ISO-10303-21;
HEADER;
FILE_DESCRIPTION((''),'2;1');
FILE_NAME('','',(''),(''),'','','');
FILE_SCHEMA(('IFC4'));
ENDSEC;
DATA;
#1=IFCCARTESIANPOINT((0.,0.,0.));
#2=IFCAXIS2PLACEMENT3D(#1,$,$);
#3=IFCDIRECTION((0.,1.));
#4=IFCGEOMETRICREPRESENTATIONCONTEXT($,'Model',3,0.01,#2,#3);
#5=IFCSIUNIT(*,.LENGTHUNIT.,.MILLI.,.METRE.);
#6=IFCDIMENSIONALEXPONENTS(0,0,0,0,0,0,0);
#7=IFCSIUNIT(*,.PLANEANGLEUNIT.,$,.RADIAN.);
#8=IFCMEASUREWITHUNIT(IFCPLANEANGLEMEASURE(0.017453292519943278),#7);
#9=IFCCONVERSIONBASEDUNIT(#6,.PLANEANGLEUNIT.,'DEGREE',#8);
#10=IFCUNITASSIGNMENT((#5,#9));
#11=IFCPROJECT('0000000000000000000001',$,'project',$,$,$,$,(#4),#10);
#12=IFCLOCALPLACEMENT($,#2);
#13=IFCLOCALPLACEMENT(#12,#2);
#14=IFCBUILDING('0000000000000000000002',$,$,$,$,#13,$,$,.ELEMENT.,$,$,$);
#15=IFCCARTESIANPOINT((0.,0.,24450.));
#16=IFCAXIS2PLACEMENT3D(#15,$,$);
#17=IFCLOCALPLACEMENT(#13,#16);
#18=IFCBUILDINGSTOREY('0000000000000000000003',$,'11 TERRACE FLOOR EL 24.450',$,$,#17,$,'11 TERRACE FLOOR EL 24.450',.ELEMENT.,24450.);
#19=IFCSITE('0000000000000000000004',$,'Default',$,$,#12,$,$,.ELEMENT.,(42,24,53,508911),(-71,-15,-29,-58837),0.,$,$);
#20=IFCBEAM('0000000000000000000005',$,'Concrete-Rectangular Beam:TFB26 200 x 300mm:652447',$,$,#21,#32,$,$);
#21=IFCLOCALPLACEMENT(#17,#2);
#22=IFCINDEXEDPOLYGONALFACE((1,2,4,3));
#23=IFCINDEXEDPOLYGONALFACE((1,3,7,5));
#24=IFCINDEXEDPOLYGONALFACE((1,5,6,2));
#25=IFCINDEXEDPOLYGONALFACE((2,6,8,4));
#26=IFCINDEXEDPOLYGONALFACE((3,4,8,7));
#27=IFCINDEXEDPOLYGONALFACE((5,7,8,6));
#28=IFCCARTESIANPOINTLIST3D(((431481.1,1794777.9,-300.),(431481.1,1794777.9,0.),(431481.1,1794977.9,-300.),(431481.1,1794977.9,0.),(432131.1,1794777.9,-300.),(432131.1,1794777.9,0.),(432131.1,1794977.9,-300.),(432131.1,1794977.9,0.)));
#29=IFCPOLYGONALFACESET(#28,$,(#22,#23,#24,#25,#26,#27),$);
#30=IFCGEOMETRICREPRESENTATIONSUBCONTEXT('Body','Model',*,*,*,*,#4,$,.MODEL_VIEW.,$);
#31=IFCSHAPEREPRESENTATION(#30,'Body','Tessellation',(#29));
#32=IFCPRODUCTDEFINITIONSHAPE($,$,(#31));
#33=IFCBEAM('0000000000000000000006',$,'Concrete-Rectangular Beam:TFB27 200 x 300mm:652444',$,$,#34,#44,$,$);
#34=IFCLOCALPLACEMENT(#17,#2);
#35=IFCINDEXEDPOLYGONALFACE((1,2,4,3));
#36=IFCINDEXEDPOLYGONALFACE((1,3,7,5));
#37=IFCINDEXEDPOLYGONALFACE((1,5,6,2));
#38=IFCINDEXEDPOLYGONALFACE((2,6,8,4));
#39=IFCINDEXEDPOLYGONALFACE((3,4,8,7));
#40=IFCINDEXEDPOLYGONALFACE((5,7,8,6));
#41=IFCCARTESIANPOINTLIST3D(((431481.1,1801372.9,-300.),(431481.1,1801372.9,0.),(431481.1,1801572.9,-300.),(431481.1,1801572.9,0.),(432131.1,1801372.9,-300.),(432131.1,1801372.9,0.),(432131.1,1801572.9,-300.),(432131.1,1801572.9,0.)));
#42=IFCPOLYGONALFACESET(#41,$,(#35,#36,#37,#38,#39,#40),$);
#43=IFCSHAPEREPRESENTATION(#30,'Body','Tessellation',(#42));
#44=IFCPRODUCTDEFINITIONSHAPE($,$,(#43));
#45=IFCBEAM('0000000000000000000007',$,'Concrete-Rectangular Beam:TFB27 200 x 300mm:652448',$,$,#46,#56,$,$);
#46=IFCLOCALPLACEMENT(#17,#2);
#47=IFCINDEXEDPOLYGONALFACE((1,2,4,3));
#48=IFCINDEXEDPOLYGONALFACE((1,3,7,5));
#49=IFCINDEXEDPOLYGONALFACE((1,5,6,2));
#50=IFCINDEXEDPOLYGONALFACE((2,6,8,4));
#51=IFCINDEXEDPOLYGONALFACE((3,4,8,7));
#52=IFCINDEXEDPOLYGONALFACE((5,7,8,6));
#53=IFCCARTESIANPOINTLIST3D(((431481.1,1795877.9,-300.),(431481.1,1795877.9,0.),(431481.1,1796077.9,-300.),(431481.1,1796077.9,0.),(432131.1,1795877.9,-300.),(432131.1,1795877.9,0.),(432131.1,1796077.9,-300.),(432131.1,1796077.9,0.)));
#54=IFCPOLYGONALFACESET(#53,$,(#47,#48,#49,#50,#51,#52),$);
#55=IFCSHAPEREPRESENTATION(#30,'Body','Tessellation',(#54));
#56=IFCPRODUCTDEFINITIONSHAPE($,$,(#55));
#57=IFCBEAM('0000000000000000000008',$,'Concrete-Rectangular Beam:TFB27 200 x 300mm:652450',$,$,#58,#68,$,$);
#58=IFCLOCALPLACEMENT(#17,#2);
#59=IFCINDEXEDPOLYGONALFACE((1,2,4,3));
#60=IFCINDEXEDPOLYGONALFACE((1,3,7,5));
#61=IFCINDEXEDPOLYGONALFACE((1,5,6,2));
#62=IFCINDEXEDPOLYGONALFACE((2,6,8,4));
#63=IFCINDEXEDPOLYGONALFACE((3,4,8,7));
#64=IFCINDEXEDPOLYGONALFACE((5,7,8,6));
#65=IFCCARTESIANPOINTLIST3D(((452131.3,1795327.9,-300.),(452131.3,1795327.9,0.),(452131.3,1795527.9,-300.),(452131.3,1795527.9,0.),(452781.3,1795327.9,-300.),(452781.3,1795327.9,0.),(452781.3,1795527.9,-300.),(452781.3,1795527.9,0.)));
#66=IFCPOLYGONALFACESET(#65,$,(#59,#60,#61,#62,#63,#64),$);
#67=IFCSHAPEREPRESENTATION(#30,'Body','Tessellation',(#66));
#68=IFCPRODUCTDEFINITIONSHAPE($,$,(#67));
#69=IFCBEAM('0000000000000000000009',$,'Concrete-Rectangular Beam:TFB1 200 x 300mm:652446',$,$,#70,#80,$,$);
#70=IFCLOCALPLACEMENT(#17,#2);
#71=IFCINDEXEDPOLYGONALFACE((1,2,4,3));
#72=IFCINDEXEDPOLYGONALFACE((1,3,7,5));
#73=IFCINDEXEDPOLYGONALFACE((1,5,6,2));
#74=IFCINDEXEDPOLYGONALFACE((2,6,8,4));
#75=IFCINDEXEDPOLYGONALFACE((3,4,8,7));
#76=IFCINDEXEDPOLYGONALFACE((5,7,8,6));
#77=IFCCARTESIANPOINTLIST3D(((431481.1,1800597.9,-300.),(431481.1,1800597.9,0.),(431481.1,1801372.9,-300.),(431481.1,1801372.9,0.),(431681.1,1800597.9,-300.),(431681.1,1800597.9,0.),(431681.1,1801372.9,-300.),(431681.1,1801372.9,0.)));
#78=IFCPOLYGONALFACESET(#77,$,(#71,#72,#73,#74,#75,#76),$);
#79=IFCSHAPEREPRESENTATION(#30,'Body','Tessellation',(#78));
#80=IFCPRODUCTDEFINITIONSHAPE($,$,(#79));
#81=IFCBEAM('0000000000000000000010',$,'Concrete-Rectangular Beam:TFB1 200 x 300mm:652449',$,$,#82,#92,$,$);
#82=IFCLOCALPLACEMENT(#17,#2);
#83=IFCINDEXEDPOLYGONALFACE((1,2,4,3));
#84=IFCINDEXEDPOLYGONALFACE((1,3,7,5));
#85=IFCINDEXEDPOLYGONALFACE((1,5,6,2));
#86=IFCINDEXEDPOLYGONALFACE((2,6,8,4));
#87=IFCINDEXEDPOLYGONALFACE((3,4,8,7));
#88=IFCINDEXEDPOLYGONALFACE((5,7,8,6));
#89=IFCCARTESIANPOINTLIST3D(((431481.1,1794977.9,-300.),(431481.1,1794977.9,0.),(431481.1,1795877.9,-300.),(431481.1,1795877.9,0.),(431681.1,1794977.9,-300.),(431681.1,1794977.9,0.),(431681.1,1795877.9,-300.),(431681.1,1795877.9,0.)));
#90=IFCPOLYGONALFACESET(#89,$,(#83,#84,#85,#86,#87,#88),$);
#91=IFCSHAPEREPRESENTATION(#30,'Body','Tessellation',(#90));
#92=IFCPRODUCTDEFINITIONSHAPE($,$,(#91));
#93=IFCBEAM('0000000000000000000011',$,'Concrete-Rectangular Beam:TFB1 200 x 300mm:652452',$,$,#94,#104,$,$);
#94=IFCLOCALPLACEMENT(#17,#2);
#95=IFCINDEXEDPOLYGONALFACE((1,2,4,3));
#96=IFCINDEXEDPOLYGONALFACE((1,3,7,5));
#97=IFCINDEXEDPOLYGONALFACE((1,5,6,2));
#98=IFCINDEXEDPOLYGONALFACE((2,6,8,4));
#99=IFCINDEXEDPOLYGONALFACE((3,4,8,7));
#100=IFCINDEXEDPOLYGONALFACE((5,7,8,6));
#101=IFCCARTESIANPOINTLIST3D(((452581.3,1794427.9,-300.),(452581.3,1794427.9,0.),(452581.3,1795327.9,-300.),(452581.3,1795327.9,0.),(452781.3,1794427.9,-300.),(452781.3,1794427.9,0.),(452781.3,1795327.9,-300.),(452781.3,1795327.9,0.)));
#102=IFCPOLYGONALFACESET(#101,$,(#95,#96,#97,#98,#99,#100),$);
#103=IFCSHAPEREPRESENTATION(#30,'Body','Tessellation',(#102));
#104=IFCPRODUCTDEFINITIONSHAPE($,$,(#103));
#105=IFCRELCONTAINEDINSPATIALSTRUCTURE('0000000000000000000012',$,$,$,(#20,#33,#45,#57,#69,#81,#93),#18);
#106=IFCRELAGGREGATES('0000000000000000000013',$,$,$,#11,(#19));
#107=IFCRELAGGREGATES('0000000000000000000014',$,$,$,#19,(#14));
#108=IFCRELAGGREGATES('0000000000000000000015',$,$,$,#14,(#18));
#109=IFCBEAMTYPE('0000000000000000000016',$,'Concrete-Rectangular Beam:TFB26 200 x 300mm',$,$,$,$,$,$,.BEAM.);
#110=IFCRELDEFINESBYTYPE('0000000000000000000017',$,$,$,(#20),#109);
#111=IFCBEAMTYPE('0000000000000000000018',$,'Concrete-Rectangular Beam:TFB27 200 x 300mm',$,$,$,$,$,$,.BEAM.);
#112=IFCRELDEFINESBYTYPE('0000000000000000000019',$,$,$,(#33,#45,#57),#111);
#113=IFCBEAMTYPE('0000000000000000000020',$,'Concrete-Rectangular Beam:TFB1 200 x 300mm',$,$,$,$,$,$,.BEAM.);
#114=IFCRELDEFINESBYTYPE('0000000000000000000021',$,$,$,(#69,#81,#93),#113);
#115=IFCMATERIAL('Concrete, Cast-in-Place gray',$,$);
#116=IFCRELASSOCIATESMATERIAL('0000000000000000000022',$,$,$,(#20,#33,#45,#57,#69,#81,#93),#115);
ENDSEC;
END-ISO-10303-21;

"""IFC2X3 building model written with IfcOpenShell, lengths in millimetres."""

from ifc_helpers import new_model, entity, si_unit, converted_unit, direction, frame, frame_2d, origin, origin_2d_with_axis, place, context, subcontext, project, spatial, rectangle, extrude, material, type_object, element, save


model = new_model("IFC2X3")

# Units and contexts
model_context = context("Model", 3, precision=0.01, world=origin(), true_north=direction((0.0, 1.0)))
body_context = subcontext(model_context, "Body", "Model", "MODEL_VIEW")
ifc_project = project(units=[si_unit("LENGTHUNIT", "METRE", prefix="MILLI"), converted_unit("PLANEANGLEUNIT", "DEGREE", entity("IfcPlaneAngleMeasure", 0.017453292519943278), si_unit("PLANEANGLEUNIT", "RADIAN"), dimensions=[0, 0, 0, 0, 0, 0, 0])], contexts=[model_context])

# Site, building, storey
site_placement = place(None, origin())
site = spatial("IfcSite", under=ifc_project, at=site_placement, Name="Default", CompositionType="ELEMENT", RefLatitude=(42, 24, 53, 508911), RefLongitude=(-71, -15, -29, -58837), RefElevation=0.0)
building_placement = place(site_placement, origin())
building = spatial("IfcBuilding", under=site, at=building_placement, CompositionType="ELEMENT")
storey_placement = place(building_placement, frame((0.0, 0.0, 24450.0)))
storey = spatial("IfcBuildingStorey", under=building, at=storey_placement, Name="11 TERRACE FLOOR EL 24.450", LongName="11 TERRACE FLOOR EL 24.450", CompositionType="ELEMENT", Elevation=24450.0)

# Beams
ifc_material = material(Name="Concrete, Cast-in-Place gray")
beam_type_1 = type_object("IfcBeamType", Name="Concrete-Rectangular Beam:TFB26 200 x 300mm", PredefinedType="BEAM")
beam_1_placement = place(storey_placement, frame((431481.1, 1794777.9, 0.0)))
element("IfcBeam", 1, at=beam_1_placement, inside=storey, type_object=beam_type_1, material=ifc_material, Name="Concrete-Rectangular Beam:TFB26 200 x 300mm:652447", context=body_context, shape_type="SweptSolid", body=[
    extrude(rectangle(XDim=300.0, YDim=200.0, at=origin_2d_with_axis()), frame((0.0, 100.0, -150.0), z_axis=(1.0, 0.0, 0.0), x_axis=(0.0, 0.0, -1.0)), (0.0, 0.0, 1.0), 650.0),
])
beam_type_2 = type_object("IfcBeamType", Name="Concrete-Rectangular Beam:TFB27 200 x 300mm", PredefinedType="BEAM")
beam_2_placement = place(storey_placement, frame((431681.1, 1801372.9, 0.0)))
element("IfcBeam", 2, at=beam_2_placement, inside=storey, type_object=beam_type_2, material=ifc_material, Name="Concrete-Rectangular Beam:TFB27 200 x 300mm:652444", context=body_context, shape_type="SweptSolid", body=[
    extrude(rectangle(XDim=300.0, YDim=200.0, at=origin_2d_with_axis()), frame((-200.0, 100.0, -150.0), z_axis=(1.0, 0.0, 0.0), x_axis=(0.0, 0.0, -1.0)), (0.0, 0.0, 1.0), 650.0),
])
beam_3_placement = place(storey_placement, frame((431481.1, 1796077.9, 0.0)))
element("IfcBeam", 3, at=beam_3_placement, inside=storey, type_object=beam_type_2, material=ifc_material, Name="Concrete-Rectangular Beam:TFB27 200 x 300mm:652448", context=body_context, shape_type="SweptSolid", body=[
    extrude(rectangle(XDim=300.0, YDim=200.0, at=origin_2d_with_axis()), frame((0.0, -100.0, -150.0), z_axis=(1.0, 0.0, 0.0), x_axis=(0.0, 0.0, -1.0)), (0.0, 0.0, 1.0), 650.0),
])
beam_4_placement = place(storey_placement, frame((452781.3, 1795527.9, 0.0), z_axis=(0.0, 0.0, 1.0), x_axis=(-1.0, 0.0, 0.0)))
element("IfcBeam", 4, at=beam_4_placement, inside=storey, type_object=beam_type_2, material=ifc_material, Name="Concrete-Rectangular Beam:TFB27 200 x 300mm:652450", context=body_context, shape_type="SweptSolid", body=[
    extrude(rectangle(XDim=300.0, YDim=200.0, at=origin_2d_with_axis()), frame((0.0, 100.0, -150.0), z_axis=(1.0, 0.0, 0.0), x_axis=(0.0, 0.0, -1.0)), (0.0, 0.0, 1.0), 650.0),
])
beam_type_3 = type_object("IfcBeamType", Name="Concrete-Rectangular Beam:TFB1 200 x 300mm", PredefinedType="BEAM")
beam_5_placement = place(storey_placement, frame((431681.1, 1801372.9, 0.0), z_axis=(0.0, 0.0, 1.0), x_axis=(0.0, -1.0, 0.0)))
element("IfcBeam", 5, at=beam_5_placement, inside=storey, type_object=beam_type_3, material=ifc_material, Name="Concrete-Rectangular Beam:TFB1 200 x 300mm:652446", context=body_context, shape_type="SweptSolid", body=[
    extrude(rectangle(XDim=300.0, YDim=200.0, at=origin_2d_with_axis()), frame((0.0, -100.0, -150.0), z_axis=(1.0, 0.0, 0.0), x_axis=(0.0, 0.0, -1.0)), (0.0, 0.0, 1.0), 775.0),
])
beam_6_placement = place(storey_placement, frame((431481.1, 1794777.9, 0.0), z_axis=(0.0, 0.0, 1.0), x_axis=(0.0, 1.0, 0.0)))
element("IfcBeam", 6, at=beam_6_placement, inside=storey, type_object=beam_type_3, material=ifc_material, Name="Concrete-Rectangular Beam:TFB1 200 x 300mm:652449", context=body_context, shape_type="SweptSolid", body=[
    extrude(rectangle(XDim=300.0, YDim=200.0, at=origin_2d_with_axis()), frame((200.0, -100.0, -150.0), z_axis=(1.0, 0.0, 0.0), x_axis=(0.0, 0.0, -1.0)), (0.0, 0.0, 1.0), 900.0),
])
beam_7_placement = place(storey_placement, frame((452781.3, 1795527.9, 0.0), z_axis=(0.0, 0.0, 1.0), x_axis=(0.0, -1.0, 0.0)))
element("IfcBeam", 7, at=beam_7_placement, inside=storey, type_object=beam_type_3, material=ifc_material, Name="Concrete-Rectangular Beam:TFB1 200 x 300mm:652452", context=body_context, shape_type="SweptSolid", body=[
    extrude(rectangle(XDim=300.0, YDim=200.0, at=frame_2d((0.0, 0.0), x_axis=(1.0, 0.0))), frame((200.0, -100.0, -150.0), z_axis=(1.0, 0.0, 0.0), x_axis=(0.0, 0.0, -1.0)), (0.0, 0.0, 1.0), 900.0),
])

save(model, "model.ifc")
